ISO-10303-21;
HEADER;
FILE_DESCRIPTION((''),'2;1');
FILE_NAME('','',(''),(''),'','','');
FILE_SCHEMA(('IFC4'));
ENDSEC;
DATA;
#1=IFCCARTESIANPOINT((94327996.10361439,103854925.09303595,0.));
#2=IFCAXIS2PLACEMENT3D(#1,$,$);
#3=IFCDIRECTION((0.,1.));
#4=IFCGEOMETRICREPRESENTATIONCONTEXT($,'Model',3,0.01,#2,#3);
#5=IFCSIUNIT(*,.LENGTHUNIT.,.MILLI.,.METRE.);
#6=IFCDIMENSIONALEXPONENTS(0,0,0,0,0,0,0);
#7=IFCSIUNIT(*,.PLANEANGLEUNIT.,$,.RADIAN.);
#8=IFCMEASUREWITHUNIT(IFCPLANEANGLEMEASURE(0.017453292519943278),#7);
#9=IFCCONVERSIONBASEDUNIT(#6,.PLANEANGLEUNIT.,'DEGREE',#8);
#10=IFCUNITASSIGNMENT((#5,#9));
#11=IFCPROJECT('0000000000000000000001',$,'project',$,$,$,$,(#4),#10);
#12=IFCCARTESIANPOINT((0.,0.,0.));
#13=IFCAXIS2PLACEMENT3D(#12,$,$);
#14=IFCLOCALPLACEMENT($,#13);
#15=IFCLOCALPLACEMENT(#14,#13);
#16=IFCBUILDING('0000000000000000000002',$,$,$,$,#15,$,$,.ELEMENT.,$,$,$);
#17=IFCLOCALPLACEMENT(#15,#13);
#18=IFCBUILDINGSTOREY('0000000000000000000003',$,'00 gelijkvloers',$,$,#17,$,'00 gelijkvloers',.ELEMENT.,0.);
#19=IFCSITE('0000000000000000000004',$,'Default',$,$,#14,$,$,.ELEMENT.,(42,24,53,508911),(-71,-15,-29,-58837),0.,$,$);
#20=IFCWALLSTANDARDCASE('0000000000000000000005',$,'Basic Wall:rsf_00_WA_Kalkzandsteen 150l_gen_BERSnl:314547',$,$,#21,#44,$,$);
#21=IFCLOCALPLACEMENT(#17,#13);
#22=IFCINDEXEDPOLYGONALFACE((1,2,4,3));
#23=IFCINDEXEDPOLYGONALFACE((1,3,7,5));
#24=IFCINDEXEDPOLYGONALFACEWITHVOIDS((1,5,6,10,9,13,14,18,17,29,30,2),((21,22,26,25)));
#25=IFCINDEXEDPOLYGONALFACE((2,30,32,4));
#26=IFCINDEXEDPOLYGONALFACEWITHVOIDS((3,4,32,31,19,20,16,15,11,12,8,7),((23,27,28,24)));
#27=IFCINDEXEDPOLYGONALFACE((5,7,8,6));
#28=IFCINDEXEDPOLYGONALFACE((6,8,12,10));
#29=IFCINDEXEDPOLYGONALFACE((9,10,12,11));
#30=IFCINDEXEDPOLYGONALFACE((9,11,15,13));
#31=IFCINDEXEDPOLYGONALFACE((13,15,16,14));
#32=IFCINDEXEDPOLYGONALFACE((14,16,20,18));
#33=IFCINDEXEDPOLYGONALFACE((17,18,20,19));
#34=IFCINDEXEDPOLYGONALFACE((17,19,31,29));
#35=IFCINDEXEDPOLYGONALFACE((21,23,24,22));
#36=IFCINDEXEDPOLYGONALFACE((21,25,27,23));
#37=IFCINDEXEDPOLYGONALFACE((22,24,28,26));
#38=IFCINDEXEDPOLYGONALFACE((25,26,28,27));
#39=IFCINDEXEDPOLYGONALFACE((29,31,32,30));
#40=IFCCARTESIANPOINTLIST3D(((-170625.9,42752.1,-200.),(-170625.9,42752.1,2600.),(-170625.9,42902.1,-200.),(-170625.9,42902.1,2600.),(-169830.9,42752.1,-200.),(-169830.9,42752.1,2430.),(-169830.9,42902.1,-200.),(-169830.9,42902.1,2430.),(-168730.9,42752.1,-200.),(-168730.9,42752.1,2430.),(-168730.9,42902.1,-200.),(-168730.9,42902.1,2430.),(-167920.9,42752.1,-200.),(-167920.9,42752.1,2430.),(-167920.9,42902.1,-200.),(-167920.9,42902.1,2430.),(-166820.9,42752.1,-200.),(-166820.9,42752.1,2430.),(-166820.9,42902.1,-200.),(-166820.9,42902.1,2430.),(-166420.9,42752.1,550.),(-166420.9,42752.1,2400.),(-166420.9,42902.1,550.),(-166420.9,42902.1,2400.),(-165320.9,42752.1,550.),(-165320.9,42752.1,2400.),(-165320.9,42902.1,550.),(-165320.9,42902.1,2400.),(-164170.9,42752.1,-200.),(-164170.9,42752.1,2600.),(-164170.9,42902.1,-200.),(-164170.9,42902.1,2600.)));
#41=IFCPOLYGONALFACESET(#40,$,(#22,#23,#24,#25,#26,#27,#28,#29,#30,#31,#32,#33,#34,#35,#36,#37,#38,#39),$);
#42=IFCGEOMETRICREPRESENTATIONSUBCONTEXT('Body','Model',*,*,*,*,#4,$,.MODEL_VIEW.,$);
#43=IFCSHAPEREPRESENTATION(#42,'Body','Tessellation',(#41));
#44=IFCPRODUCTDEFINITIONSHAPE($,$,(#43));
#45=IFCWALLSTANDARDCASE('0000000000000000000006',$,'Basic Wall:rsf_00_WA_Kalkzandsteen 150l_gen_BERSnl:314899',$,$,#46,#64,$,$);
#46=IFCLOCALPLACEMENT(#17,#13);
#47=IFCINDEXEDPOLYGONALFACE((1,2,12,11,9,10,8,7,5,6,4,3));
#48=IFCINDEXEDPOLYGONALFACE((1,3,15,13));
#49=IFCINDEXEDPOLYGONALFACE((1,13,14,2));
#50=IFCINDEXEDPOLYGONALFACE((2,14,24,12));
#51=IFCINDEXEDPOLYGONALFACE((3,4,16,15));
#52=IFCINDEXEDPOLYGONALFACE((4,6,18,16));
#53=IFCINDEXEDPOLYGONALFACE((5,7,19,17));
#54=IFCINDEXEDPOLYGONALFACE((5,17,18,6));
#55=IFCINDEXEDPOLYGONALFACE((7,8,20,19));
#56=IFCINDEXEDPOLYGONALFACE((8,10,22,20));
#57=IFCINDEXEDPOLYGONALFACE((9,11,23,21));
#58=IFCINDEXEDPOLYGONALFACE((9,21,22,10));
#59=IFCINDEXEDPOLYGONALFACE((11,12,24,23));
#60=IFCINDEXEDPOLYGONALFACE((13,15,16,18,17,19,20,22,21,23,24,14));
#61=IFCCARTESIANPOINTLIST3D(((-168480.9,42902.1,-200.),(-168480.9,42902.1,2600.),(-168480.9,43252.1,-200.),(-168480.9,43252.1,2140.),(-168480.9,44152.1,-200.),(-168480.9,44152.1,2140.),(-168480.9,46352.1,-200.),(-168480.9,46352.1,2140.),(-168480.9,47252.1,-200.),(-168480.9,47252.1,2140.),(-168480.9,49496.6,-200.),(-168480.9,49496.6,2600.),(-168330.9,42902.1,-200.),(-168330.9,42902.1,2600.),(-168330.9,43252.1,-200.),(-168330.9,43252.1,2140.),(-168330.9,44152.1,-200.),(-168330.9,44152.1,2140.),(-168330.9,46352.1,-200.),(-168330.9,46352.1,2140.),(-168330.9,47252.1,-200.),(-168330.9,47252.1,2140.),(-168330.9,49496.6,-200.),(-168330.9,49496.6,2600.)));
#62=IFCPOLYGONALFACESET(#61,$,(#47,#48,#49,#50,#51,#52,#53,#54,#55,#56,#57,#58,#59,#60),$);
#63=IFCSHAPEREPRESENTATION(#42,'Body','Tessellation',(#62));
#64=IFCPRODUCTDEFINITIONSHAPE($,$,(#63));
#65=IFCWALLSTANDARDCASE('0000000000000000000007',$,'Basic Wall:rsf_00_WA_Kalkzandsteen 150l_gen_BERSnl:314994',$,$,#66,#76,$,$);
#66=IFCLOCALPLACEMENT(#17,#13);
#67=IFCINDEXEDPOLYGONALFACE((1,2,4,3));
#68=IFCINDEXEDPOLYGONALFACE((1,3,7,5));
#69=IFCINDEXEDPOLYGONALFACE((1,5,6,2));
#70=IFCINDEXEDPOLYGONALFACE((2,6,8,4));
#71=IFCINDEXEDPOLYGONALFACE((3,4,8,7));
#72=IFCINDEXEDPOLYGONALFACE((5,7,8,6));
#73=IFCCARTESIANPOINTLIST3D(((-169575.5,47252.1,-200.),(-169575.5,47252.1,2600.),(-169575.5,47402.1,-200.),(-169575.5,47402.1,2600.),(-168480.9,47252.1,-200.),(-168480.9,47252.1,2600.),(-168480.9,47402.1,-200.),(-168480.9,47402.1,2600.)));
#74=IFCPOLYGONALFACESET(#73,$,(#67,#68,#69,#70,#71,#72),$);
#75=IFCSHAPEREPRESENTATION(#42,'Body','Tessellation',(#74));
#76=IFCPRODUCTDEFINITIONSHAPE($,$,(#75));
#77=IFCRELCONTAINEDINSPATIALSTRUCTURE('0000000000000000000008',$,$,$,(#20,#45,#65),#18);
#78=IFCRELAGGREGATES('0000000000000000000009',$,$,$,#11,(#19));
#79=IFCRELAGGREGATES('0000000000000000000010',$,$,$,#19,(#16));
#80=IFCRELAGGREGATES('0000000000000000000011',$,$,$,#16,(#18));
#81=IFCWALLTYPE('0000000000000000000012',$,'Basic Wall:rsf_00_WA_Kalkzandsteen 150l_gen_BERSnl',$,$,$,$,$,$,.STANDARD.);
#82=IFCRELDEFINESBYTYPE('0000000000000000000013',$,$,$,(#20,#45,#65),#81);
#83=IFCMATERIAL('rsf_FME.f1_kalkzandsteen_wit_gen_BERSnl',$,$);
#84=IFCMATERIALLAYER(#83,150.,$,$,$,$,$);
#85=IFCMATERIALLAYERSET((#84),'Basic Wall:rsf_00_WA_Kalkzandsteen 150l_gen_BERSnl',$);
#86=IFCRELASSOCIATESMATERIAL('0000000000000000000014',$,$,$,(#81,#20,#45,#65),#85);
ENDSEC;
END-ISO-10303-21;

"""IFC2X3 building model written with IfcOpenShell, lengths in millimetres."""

from ifc_helpers import new_model, entity, si_unit, converted_unit, direction, frame, frame_2d, origin, origin_2d_with_axis, place, context, subcontext, project, spatial, polyline, rectangle, extrude, clip, bounded_halfspace, material, layer, layer_set, layer_usage, type_object, element, save


model = new_model("IFC2X3")

# Units and contexts
model_context = context("Model", 3, precision=0.01, world=frame((94327996.10361439, 103854925.09303595, 0.0)), true_north=direction((0.0, 1.0)))
body_context = subcontext(model_context, "Body", "Model", "MODEL_VIEW")
ifc_project = project(units=[si_unit("LENGTHUNIT", "METRE", prefix="MILLI"), converted_unit("PLANEANGLEUNIT", "DEGREE", entity("IfcPlaneAngleMeasure", 0.017453292519943278), si_unit("PLANEANGLEUNIT", "RADIAN"), dimensions=[0, 0, 0, 0, 0, 0, 0])], contexts=[model_context])

# Site, building, storey
site_placement = place(None, origin())
site = spatial("IfcSite", under=ifc_project, at=site_placement, Name="Default", CompositionType="ELEMENT", RefLatitude=(42, 24, 53, 508911), RefLongitude=(-71, -15, -29, -58837), RefElevation=0.0)
building_placement = place(site_placement, origin())
building = spatial("IfcBuilding", under=site, at=building_placement, CompositionType="ELEMENT")
storey_placement = place(building_placement, origin())
storey = spatial("IfcBuildingStorey", under=building, at=storey_placement, Name="00 gelijkvloers", LongName="00 gelijkvloers", CompositionType="ELEMENT", Elevation=0.0)

# Shared definitions
ifc_material_1 = material(Name="rsf_FME.f1_kalkzandsteen_wit_gen_BERSnl")
ifc_layer_1 = layer(ifc_material_1, 150.0)
ifc_layer_set_1 = layer_set([ifc_layer_1], Name="Basic Wall:rsf_00_WA_Kalkzandsteen 150l_gen_BERSnl")
wall_type_1 = type_object("IfcWallType", Name="Basic Wall:rsf_00_WA_Kalkzandsteen 150l_gen_BERSnl", PredefinedType="STANDARD", material=ifc_layer_set_1)

# Walls, openings
ifc_layer_usage_1 = layer_usage(ifc_layer_set_1, "AXIS2", "NEGATIVE", 75.0)
wall_1_placement = place(storey_placement, frame((-170625.9, 42827.1, -200.0)))
wall_1 = element("IfcWallStandardCase", 1, at=wall_1_placement, inside=storey, type_object=wall_type_1, material=ifc_layer_usage_1, Name="Basic Wall:rsf_00_WA_Kalkzandsteen 150l_gen_BERSnl:314547", context=body_context, shape_type="Clipping", body=[
    clip(extrude(rectangle(XDim=6455.0, YDim=150.0, at=frame_2d((3227.5, 0.0), x_axis=(-1.0, 0.0))), origin(), (0.0, 0.0, 1.0), 2800.0), bounded_halfspace(frame((0.0, -75.0, 2800.0), z_axis=(0.0, 0.0, -1.0), x_axis=(1.0, 0.0, 0.0)), True, frame((0.0, -75.0, 2800.0)), polyline([(0.0, 0.0), (6455.0, 0.0), (6455.0, 150.0), (6305.0, 150.0), (2295.0, 150.0), (2145.0, 150.0), (150.0, 150.0), (0.0, 150.0), (0.0, 0.0)]))),
])
opening_1_placement = place(wall_1_placement, frame((170625.9, -42827.1, 200.0)))
element("IfcOpeningElement", 2, at=opening_1_placement, cuts=wall_1, ObjectType="Opening", context=body_context, shape_type="SweptSolid", body=[
    extrude(rectangle(XDim=2630.0, YDim=1100.0, at=frame_2d((0.0, 0.0), x_axis=(1.0, 0.0))), frame((-169280.9, 41378.1, 1115.0), z_axis=(0.0, 1.0, 0.0), x_axis=(0.0, 0.0, 1.0)), (0.0, 0.0, 1.0), 3048.0),
])
opening_2_placement = place(wall_1_placement, frame((170625.9, -42827.1, 200.0)))
element("IfcOpeningElement", 3, at=opening_2_placement, cuts=wall_1, ObjectType="Opening", context=body_context, shape_type="SweptSolid", body=[
    extrude(rectangle(XDim=2630.0, YDim=1100.0, at=frame_2d((0.0, 0.0), x_axis=(1.0, 0.0))), frame((-167370.9, 41378.1, 1115.0), z_axis=(0.0, 1.0, 0.0), x_axis=(0.0, 0.0, 1.0)), (0.0, 0.0, 1.0), 3048.0),
])
opening_3_placement = place(wall_1_placement, frame((170625.9, -42827.1, 200.0)))
element("IfcOpeningElement", 4, at=opening_3_placement, cuts=wall_1, ObjectType="Opening", context=body_context, shape_type="SweptSolid", body=[
    extrude(rectangle(XDim=1850.0, YDim=1100.0, at=frame_2d((0.0, 0.0), x_axis=(1.0, 0.0))), frame((-165870.9, 41378.1, 1475.0), z_axis=(0.0, 1.0, 0.0), x_axis=(0.0, 0.0, 1.0)), (0.0, 0.0, 1.0), 3048.0),
])
ifc_layer_usage_2 = layer_usage(ifc_layer_set_1, "AXIS2", "POSITIVE", -75.0)
wall_2_placement = place(storey_placement, frame((-168405.9, 42902.1, -200.0), z_axis=(0.0, 0.0, 1.0), x_axis=(0.0, 1.0, 0.0)))
wall_2 = element("IfcWallStandardCase", 5, at=wall_2_placement, inside=storey, type_object=wall_type_1, material=ifc_layer_usage_2, Name="Basic Wall:rsf_00_WA_Kalkzandsteen 150l_gen_BERSnl:314899", context=body_context, shape_type="Clipping", body=[
    clip(extrude(rectangle(XDim=6594.5, YDim=150.0, at=frame_2d((3297.3, 0.0), x_axis=(1.0, 0.0))), origin(), (0.0, 0.0, 1.0), 2800.0), bounded_halfspace(frame((0.0, -75.0, 2800.0), z_axis=(0.0, 0.0, -1.0), x_axis=(0.0, -1.0, 0.0)), True, frame((0.0, -75.0, 2800.0)), polyline([(0.0, 0.0), (6594.5, 0.0), (6594.5, 150.0), (4500.0, 150.0), (4350.0, 150.0), (0.0, 150.0), (0.0, 0.0)]))),
])
opening_4_placement = place(wall_2_placement, frame((-42902.1, -168405.9, 200.0), z_axis=(0.0, 0.0, 1.0), x_axis=(0.0, -1.0, 0.0)))
element("IfcOpeningElement", 6, at=opening_4_placement, cuts=wall_2, ObjectType="Opening", context=body_context, shape_type="SweptSolid", body=[
    extrude(rectangle(XDim=2340.0, YDim=900.0, at=origin_2d_with_axis()), frame((-166956.9, 46802.1, 970.0), z_axis=(-1.0, 0.0, 0.0), x_axis=(0.0, 0.0, 1.0)), (0.0, 0.0, 1.0), 3048.0),
])
opening_5_placement = place(wall_2_placement, frame((-42902.1, -168405.9, 200.0), z_axis=(0.0, 0.0, 1.0), x_axis=(0.0, -1.0, 0.0)))
element("IfcOpeningElement", 7, at=opening_5_placement, cuts=wall_2, ObjectType="Opening", context=body_context, shape_type="SweptSolid", body=[
    extrude(rectangle(XDim=2340.0, YDim=900.0, at=origin_2d_with_axis()), frame((-166956.9, 43702.1, 970.0), z_axis=(-1.0, 0.0, 0.0), x_axis=(0.0, 0.0, 1.0)), (0.0, 0.0, 1.0), 3048.0),
])

# Wall
ifc_layer_usage_3 = layer_usage(ifc_layer_set_1, "AXIS2", "POSITIVE", -75.0)
wall_3_placement = place(storey_placement, frame((-168480.9, 47327.1, -200.0), z_axis=(0.0, 0.0, 1.0), x_axis=(-1.0, 0.0, 0.0)))
element("IfcWallStandardCase", 8, at=wall_3_placement, inside=storey, type_object=wall_type_1, material=ifc_layer_usage_3, Name="Basic Wall:rsf_00_WA_Kalkzandsteen 150l_gen_BERSnl:314994", context=body_context, shape_type="Clipping", body=[
    clip(extrude(rectangle(XDim=1094.6, YDim=150.0, at=frame_2d((547.3, 0.0), x_axis=(-1.0, 0.0))), origin(), (0.0, 0.0, 1.0), 2800.0), bounded_halfspace(frame((0.0, -75.0, 2800.0), z_axis=(0.0, 0.0, -1.0), x_axis=(-1.0, 0.0, 0.0)), True, frame((0.0, -75.0, 2800.0)), polyline([(0.0, 0.0), (1094.6, 0.0), (1094.6, 150.0), (0.0, 150.0), (0.0, 0.0)]))),
])

save(model, "model.ifc")
